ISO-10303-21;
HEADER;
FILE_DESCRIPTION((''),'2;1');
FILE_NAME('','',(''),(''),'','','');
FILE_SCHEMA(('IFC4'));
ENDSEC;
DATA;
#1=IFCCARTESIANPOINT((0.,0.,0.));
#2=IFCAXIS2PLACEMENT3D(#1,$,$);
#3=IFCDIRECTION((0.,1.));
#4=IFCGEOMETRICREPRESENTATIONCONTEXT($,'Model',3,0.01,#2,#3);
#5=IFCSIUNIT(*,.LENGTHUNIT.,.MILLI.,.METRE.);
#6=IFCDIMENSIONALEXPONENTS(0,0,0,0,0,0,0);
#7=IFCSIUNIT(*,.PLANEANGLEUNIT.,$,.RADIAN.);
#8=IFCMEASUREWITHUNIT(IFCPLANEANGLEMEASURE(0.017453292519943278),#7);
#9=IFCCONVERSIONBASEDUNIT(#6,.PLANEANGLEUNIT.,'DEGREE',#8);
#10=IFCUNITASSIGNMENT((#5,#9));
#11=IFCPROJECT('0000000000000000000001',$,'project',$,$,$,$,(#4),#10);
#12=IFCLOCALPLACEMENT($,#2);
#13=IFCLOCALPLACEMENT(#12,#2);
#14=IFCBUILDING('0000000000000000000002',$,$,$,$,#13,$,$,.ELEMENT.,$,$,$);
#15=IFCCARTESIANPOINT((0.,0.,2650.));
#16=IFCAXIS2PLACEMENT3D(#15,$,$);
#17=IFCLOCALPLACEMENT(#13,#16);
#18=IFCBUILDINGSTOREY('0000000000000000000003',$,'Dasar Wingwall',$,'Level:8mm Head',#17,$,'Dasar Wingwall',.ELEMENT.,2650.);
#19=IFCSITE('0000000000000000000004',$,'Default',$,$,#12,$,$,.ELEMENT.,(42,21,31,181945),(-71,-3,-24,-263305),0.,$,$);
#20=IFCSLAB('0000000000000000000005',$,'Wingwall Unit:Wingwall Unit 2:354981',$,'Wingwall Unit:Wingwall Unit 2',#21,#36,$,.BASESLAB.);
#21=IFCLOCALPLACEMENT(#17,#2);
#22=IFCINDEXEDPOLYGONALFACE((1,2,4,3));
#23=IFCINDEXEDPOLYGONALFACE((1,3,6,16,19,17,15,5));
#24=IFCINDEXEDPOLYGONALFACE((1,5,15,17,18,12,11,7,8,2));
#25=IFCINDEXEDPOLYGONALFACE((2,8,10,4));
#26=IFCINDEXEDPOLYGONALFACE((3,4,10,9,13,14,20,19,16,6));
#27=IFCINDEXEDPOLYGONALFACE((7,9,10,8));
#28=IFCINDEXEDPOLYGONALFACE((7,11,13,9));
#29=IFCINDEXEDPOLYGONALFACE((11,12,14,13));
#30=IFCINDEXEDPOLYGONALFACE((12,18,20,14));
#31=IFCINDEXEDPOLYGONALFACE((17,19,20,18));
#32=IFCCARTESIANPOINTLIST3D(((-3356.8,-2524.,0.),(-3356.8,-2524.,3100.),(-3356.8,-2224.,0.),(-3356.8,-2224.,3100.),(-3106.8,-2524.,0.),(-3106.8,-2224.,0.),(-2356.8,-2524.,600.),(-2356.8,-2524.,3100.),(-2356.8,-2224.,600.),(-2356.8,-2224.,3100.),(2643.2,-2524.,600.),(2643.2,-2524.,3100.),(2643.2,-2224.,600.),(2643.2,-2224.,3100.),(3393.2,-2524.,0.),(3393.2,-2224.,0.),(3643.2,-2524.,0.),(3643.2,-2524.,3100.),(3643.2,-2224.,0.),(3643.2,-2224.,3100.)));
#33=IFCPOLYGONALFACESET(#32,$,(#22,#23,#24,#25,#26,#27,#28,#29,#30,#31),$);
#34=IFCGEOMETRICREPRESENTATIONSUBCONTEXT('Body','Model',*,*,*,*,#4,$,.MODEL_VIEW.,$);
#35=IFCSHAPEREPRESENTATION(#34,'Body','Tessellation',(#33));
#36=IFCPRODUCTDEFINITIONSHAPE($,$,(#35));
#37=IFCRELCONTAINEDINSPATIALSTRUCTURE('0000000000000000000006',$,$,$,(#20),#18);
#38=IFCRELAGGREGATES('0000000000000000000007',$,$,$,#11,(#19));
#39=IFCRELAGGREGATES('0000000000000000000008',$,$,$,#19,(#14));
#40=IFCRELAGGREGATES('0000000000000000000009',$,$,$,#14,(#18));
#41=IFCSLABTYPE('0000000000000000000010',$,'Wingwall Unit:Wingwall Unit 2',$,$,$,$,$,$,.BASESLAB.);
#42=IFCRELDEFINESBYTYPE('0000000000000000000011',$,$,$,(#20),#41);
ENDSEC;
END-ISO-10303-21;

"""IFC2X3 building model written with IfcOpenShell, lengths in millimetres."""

from ifc_helpers import new_model, entity, si_unit, converted_unit, direction, frame, origin, place, context, subcontext, project, spatial, polyline, outline, extrude, type_object, element, save


model = new_model("IFC2X3")

# Units and contexts
model_context = context("Model", 3, precision=0.01, world=origin(), true_north=direction((0.0, 1.0)))
body_context = subcontext(model_context, "Body", "Model", "MODEL_VIEW")
ifc_project = project(units=[si_unit("LENGTHUNIT", "METRE", prefix="MILLI"), converted_unit("PLANEANGLEUNIT", "DEGREE", entity("IfcPlaneAngleMeasure", 0.017453292519943278), si_unit("PLANEANGLEUNIT", "RADIAN"), dimensions=[0, 0, 0, 0, 0, 0, 0])], contexts=[model_context])

# Site, building, storey
site_placement = place(None, origin())
site = spatial("IfcSite", under=ifc_project, at=site_placement, Name="Default", CompositionType="ELEMENT", RefLatitude=(42, 21, 31, 181945), RefLongitude=(-71, -3, -24, -263305), RefElevation=0.0)
building_placement = place(site_placement, origin())
building = spatial("IfcBuilding", under=site, at=building_placement, CompositionType="ELEMENT")
storey_placement = place(building_placement, frame((0.0, 0.0, 2650.0)))
storey = spatial("IfcBuildingStorey", under=building, at=storey_placement, Name="Dasar Wingwall", ObjectType="Level:8mm Head", LongName="Dasar Wingwall", CompositionType="ELEMENT", Elevation=2650.0)

# Slab
slab_type_1 = type_object("IfcSlabType", Name="Wingwall Unit:Wingwall Unit 2", PredefinedType="BASESLAB")
slab_1_placement = place(storey_placement, origin())
element("IfcSlab", 1, at=slab_1_placement, inside=storey, type_object=slab_type_1, Name="Wingwall Unit:Wingwall Unit 2:354981", ObjectType="Wingwall Unit:Wingwall Unit 2", PredefinedType="BASESLAB", context=body_context, shape_type="SweptSolid", body=[
    extrude(outline(polyline([(-1360.0, -3500.0), (1740.0, -3500.0), (1740.0, -2500.0), (-760.0, -2500.0), (-760.0, 2500.0), (1740.0, 2500.0), (1740.0, 3500.0), (-1360.0, 3500.0), (-1360.0, 3250.0), (-1360.0, -3250.0), (-1360.0, -3500.0)])), frame((143.2, -2524.0, 1360.0), z_axis=(0.0, 1.0, 0.0), x_axis=(0.0, 0.0, 1.0)), (0.0, 0.0, 1.0), 300.0),
])

save(model, "model.ifc")
